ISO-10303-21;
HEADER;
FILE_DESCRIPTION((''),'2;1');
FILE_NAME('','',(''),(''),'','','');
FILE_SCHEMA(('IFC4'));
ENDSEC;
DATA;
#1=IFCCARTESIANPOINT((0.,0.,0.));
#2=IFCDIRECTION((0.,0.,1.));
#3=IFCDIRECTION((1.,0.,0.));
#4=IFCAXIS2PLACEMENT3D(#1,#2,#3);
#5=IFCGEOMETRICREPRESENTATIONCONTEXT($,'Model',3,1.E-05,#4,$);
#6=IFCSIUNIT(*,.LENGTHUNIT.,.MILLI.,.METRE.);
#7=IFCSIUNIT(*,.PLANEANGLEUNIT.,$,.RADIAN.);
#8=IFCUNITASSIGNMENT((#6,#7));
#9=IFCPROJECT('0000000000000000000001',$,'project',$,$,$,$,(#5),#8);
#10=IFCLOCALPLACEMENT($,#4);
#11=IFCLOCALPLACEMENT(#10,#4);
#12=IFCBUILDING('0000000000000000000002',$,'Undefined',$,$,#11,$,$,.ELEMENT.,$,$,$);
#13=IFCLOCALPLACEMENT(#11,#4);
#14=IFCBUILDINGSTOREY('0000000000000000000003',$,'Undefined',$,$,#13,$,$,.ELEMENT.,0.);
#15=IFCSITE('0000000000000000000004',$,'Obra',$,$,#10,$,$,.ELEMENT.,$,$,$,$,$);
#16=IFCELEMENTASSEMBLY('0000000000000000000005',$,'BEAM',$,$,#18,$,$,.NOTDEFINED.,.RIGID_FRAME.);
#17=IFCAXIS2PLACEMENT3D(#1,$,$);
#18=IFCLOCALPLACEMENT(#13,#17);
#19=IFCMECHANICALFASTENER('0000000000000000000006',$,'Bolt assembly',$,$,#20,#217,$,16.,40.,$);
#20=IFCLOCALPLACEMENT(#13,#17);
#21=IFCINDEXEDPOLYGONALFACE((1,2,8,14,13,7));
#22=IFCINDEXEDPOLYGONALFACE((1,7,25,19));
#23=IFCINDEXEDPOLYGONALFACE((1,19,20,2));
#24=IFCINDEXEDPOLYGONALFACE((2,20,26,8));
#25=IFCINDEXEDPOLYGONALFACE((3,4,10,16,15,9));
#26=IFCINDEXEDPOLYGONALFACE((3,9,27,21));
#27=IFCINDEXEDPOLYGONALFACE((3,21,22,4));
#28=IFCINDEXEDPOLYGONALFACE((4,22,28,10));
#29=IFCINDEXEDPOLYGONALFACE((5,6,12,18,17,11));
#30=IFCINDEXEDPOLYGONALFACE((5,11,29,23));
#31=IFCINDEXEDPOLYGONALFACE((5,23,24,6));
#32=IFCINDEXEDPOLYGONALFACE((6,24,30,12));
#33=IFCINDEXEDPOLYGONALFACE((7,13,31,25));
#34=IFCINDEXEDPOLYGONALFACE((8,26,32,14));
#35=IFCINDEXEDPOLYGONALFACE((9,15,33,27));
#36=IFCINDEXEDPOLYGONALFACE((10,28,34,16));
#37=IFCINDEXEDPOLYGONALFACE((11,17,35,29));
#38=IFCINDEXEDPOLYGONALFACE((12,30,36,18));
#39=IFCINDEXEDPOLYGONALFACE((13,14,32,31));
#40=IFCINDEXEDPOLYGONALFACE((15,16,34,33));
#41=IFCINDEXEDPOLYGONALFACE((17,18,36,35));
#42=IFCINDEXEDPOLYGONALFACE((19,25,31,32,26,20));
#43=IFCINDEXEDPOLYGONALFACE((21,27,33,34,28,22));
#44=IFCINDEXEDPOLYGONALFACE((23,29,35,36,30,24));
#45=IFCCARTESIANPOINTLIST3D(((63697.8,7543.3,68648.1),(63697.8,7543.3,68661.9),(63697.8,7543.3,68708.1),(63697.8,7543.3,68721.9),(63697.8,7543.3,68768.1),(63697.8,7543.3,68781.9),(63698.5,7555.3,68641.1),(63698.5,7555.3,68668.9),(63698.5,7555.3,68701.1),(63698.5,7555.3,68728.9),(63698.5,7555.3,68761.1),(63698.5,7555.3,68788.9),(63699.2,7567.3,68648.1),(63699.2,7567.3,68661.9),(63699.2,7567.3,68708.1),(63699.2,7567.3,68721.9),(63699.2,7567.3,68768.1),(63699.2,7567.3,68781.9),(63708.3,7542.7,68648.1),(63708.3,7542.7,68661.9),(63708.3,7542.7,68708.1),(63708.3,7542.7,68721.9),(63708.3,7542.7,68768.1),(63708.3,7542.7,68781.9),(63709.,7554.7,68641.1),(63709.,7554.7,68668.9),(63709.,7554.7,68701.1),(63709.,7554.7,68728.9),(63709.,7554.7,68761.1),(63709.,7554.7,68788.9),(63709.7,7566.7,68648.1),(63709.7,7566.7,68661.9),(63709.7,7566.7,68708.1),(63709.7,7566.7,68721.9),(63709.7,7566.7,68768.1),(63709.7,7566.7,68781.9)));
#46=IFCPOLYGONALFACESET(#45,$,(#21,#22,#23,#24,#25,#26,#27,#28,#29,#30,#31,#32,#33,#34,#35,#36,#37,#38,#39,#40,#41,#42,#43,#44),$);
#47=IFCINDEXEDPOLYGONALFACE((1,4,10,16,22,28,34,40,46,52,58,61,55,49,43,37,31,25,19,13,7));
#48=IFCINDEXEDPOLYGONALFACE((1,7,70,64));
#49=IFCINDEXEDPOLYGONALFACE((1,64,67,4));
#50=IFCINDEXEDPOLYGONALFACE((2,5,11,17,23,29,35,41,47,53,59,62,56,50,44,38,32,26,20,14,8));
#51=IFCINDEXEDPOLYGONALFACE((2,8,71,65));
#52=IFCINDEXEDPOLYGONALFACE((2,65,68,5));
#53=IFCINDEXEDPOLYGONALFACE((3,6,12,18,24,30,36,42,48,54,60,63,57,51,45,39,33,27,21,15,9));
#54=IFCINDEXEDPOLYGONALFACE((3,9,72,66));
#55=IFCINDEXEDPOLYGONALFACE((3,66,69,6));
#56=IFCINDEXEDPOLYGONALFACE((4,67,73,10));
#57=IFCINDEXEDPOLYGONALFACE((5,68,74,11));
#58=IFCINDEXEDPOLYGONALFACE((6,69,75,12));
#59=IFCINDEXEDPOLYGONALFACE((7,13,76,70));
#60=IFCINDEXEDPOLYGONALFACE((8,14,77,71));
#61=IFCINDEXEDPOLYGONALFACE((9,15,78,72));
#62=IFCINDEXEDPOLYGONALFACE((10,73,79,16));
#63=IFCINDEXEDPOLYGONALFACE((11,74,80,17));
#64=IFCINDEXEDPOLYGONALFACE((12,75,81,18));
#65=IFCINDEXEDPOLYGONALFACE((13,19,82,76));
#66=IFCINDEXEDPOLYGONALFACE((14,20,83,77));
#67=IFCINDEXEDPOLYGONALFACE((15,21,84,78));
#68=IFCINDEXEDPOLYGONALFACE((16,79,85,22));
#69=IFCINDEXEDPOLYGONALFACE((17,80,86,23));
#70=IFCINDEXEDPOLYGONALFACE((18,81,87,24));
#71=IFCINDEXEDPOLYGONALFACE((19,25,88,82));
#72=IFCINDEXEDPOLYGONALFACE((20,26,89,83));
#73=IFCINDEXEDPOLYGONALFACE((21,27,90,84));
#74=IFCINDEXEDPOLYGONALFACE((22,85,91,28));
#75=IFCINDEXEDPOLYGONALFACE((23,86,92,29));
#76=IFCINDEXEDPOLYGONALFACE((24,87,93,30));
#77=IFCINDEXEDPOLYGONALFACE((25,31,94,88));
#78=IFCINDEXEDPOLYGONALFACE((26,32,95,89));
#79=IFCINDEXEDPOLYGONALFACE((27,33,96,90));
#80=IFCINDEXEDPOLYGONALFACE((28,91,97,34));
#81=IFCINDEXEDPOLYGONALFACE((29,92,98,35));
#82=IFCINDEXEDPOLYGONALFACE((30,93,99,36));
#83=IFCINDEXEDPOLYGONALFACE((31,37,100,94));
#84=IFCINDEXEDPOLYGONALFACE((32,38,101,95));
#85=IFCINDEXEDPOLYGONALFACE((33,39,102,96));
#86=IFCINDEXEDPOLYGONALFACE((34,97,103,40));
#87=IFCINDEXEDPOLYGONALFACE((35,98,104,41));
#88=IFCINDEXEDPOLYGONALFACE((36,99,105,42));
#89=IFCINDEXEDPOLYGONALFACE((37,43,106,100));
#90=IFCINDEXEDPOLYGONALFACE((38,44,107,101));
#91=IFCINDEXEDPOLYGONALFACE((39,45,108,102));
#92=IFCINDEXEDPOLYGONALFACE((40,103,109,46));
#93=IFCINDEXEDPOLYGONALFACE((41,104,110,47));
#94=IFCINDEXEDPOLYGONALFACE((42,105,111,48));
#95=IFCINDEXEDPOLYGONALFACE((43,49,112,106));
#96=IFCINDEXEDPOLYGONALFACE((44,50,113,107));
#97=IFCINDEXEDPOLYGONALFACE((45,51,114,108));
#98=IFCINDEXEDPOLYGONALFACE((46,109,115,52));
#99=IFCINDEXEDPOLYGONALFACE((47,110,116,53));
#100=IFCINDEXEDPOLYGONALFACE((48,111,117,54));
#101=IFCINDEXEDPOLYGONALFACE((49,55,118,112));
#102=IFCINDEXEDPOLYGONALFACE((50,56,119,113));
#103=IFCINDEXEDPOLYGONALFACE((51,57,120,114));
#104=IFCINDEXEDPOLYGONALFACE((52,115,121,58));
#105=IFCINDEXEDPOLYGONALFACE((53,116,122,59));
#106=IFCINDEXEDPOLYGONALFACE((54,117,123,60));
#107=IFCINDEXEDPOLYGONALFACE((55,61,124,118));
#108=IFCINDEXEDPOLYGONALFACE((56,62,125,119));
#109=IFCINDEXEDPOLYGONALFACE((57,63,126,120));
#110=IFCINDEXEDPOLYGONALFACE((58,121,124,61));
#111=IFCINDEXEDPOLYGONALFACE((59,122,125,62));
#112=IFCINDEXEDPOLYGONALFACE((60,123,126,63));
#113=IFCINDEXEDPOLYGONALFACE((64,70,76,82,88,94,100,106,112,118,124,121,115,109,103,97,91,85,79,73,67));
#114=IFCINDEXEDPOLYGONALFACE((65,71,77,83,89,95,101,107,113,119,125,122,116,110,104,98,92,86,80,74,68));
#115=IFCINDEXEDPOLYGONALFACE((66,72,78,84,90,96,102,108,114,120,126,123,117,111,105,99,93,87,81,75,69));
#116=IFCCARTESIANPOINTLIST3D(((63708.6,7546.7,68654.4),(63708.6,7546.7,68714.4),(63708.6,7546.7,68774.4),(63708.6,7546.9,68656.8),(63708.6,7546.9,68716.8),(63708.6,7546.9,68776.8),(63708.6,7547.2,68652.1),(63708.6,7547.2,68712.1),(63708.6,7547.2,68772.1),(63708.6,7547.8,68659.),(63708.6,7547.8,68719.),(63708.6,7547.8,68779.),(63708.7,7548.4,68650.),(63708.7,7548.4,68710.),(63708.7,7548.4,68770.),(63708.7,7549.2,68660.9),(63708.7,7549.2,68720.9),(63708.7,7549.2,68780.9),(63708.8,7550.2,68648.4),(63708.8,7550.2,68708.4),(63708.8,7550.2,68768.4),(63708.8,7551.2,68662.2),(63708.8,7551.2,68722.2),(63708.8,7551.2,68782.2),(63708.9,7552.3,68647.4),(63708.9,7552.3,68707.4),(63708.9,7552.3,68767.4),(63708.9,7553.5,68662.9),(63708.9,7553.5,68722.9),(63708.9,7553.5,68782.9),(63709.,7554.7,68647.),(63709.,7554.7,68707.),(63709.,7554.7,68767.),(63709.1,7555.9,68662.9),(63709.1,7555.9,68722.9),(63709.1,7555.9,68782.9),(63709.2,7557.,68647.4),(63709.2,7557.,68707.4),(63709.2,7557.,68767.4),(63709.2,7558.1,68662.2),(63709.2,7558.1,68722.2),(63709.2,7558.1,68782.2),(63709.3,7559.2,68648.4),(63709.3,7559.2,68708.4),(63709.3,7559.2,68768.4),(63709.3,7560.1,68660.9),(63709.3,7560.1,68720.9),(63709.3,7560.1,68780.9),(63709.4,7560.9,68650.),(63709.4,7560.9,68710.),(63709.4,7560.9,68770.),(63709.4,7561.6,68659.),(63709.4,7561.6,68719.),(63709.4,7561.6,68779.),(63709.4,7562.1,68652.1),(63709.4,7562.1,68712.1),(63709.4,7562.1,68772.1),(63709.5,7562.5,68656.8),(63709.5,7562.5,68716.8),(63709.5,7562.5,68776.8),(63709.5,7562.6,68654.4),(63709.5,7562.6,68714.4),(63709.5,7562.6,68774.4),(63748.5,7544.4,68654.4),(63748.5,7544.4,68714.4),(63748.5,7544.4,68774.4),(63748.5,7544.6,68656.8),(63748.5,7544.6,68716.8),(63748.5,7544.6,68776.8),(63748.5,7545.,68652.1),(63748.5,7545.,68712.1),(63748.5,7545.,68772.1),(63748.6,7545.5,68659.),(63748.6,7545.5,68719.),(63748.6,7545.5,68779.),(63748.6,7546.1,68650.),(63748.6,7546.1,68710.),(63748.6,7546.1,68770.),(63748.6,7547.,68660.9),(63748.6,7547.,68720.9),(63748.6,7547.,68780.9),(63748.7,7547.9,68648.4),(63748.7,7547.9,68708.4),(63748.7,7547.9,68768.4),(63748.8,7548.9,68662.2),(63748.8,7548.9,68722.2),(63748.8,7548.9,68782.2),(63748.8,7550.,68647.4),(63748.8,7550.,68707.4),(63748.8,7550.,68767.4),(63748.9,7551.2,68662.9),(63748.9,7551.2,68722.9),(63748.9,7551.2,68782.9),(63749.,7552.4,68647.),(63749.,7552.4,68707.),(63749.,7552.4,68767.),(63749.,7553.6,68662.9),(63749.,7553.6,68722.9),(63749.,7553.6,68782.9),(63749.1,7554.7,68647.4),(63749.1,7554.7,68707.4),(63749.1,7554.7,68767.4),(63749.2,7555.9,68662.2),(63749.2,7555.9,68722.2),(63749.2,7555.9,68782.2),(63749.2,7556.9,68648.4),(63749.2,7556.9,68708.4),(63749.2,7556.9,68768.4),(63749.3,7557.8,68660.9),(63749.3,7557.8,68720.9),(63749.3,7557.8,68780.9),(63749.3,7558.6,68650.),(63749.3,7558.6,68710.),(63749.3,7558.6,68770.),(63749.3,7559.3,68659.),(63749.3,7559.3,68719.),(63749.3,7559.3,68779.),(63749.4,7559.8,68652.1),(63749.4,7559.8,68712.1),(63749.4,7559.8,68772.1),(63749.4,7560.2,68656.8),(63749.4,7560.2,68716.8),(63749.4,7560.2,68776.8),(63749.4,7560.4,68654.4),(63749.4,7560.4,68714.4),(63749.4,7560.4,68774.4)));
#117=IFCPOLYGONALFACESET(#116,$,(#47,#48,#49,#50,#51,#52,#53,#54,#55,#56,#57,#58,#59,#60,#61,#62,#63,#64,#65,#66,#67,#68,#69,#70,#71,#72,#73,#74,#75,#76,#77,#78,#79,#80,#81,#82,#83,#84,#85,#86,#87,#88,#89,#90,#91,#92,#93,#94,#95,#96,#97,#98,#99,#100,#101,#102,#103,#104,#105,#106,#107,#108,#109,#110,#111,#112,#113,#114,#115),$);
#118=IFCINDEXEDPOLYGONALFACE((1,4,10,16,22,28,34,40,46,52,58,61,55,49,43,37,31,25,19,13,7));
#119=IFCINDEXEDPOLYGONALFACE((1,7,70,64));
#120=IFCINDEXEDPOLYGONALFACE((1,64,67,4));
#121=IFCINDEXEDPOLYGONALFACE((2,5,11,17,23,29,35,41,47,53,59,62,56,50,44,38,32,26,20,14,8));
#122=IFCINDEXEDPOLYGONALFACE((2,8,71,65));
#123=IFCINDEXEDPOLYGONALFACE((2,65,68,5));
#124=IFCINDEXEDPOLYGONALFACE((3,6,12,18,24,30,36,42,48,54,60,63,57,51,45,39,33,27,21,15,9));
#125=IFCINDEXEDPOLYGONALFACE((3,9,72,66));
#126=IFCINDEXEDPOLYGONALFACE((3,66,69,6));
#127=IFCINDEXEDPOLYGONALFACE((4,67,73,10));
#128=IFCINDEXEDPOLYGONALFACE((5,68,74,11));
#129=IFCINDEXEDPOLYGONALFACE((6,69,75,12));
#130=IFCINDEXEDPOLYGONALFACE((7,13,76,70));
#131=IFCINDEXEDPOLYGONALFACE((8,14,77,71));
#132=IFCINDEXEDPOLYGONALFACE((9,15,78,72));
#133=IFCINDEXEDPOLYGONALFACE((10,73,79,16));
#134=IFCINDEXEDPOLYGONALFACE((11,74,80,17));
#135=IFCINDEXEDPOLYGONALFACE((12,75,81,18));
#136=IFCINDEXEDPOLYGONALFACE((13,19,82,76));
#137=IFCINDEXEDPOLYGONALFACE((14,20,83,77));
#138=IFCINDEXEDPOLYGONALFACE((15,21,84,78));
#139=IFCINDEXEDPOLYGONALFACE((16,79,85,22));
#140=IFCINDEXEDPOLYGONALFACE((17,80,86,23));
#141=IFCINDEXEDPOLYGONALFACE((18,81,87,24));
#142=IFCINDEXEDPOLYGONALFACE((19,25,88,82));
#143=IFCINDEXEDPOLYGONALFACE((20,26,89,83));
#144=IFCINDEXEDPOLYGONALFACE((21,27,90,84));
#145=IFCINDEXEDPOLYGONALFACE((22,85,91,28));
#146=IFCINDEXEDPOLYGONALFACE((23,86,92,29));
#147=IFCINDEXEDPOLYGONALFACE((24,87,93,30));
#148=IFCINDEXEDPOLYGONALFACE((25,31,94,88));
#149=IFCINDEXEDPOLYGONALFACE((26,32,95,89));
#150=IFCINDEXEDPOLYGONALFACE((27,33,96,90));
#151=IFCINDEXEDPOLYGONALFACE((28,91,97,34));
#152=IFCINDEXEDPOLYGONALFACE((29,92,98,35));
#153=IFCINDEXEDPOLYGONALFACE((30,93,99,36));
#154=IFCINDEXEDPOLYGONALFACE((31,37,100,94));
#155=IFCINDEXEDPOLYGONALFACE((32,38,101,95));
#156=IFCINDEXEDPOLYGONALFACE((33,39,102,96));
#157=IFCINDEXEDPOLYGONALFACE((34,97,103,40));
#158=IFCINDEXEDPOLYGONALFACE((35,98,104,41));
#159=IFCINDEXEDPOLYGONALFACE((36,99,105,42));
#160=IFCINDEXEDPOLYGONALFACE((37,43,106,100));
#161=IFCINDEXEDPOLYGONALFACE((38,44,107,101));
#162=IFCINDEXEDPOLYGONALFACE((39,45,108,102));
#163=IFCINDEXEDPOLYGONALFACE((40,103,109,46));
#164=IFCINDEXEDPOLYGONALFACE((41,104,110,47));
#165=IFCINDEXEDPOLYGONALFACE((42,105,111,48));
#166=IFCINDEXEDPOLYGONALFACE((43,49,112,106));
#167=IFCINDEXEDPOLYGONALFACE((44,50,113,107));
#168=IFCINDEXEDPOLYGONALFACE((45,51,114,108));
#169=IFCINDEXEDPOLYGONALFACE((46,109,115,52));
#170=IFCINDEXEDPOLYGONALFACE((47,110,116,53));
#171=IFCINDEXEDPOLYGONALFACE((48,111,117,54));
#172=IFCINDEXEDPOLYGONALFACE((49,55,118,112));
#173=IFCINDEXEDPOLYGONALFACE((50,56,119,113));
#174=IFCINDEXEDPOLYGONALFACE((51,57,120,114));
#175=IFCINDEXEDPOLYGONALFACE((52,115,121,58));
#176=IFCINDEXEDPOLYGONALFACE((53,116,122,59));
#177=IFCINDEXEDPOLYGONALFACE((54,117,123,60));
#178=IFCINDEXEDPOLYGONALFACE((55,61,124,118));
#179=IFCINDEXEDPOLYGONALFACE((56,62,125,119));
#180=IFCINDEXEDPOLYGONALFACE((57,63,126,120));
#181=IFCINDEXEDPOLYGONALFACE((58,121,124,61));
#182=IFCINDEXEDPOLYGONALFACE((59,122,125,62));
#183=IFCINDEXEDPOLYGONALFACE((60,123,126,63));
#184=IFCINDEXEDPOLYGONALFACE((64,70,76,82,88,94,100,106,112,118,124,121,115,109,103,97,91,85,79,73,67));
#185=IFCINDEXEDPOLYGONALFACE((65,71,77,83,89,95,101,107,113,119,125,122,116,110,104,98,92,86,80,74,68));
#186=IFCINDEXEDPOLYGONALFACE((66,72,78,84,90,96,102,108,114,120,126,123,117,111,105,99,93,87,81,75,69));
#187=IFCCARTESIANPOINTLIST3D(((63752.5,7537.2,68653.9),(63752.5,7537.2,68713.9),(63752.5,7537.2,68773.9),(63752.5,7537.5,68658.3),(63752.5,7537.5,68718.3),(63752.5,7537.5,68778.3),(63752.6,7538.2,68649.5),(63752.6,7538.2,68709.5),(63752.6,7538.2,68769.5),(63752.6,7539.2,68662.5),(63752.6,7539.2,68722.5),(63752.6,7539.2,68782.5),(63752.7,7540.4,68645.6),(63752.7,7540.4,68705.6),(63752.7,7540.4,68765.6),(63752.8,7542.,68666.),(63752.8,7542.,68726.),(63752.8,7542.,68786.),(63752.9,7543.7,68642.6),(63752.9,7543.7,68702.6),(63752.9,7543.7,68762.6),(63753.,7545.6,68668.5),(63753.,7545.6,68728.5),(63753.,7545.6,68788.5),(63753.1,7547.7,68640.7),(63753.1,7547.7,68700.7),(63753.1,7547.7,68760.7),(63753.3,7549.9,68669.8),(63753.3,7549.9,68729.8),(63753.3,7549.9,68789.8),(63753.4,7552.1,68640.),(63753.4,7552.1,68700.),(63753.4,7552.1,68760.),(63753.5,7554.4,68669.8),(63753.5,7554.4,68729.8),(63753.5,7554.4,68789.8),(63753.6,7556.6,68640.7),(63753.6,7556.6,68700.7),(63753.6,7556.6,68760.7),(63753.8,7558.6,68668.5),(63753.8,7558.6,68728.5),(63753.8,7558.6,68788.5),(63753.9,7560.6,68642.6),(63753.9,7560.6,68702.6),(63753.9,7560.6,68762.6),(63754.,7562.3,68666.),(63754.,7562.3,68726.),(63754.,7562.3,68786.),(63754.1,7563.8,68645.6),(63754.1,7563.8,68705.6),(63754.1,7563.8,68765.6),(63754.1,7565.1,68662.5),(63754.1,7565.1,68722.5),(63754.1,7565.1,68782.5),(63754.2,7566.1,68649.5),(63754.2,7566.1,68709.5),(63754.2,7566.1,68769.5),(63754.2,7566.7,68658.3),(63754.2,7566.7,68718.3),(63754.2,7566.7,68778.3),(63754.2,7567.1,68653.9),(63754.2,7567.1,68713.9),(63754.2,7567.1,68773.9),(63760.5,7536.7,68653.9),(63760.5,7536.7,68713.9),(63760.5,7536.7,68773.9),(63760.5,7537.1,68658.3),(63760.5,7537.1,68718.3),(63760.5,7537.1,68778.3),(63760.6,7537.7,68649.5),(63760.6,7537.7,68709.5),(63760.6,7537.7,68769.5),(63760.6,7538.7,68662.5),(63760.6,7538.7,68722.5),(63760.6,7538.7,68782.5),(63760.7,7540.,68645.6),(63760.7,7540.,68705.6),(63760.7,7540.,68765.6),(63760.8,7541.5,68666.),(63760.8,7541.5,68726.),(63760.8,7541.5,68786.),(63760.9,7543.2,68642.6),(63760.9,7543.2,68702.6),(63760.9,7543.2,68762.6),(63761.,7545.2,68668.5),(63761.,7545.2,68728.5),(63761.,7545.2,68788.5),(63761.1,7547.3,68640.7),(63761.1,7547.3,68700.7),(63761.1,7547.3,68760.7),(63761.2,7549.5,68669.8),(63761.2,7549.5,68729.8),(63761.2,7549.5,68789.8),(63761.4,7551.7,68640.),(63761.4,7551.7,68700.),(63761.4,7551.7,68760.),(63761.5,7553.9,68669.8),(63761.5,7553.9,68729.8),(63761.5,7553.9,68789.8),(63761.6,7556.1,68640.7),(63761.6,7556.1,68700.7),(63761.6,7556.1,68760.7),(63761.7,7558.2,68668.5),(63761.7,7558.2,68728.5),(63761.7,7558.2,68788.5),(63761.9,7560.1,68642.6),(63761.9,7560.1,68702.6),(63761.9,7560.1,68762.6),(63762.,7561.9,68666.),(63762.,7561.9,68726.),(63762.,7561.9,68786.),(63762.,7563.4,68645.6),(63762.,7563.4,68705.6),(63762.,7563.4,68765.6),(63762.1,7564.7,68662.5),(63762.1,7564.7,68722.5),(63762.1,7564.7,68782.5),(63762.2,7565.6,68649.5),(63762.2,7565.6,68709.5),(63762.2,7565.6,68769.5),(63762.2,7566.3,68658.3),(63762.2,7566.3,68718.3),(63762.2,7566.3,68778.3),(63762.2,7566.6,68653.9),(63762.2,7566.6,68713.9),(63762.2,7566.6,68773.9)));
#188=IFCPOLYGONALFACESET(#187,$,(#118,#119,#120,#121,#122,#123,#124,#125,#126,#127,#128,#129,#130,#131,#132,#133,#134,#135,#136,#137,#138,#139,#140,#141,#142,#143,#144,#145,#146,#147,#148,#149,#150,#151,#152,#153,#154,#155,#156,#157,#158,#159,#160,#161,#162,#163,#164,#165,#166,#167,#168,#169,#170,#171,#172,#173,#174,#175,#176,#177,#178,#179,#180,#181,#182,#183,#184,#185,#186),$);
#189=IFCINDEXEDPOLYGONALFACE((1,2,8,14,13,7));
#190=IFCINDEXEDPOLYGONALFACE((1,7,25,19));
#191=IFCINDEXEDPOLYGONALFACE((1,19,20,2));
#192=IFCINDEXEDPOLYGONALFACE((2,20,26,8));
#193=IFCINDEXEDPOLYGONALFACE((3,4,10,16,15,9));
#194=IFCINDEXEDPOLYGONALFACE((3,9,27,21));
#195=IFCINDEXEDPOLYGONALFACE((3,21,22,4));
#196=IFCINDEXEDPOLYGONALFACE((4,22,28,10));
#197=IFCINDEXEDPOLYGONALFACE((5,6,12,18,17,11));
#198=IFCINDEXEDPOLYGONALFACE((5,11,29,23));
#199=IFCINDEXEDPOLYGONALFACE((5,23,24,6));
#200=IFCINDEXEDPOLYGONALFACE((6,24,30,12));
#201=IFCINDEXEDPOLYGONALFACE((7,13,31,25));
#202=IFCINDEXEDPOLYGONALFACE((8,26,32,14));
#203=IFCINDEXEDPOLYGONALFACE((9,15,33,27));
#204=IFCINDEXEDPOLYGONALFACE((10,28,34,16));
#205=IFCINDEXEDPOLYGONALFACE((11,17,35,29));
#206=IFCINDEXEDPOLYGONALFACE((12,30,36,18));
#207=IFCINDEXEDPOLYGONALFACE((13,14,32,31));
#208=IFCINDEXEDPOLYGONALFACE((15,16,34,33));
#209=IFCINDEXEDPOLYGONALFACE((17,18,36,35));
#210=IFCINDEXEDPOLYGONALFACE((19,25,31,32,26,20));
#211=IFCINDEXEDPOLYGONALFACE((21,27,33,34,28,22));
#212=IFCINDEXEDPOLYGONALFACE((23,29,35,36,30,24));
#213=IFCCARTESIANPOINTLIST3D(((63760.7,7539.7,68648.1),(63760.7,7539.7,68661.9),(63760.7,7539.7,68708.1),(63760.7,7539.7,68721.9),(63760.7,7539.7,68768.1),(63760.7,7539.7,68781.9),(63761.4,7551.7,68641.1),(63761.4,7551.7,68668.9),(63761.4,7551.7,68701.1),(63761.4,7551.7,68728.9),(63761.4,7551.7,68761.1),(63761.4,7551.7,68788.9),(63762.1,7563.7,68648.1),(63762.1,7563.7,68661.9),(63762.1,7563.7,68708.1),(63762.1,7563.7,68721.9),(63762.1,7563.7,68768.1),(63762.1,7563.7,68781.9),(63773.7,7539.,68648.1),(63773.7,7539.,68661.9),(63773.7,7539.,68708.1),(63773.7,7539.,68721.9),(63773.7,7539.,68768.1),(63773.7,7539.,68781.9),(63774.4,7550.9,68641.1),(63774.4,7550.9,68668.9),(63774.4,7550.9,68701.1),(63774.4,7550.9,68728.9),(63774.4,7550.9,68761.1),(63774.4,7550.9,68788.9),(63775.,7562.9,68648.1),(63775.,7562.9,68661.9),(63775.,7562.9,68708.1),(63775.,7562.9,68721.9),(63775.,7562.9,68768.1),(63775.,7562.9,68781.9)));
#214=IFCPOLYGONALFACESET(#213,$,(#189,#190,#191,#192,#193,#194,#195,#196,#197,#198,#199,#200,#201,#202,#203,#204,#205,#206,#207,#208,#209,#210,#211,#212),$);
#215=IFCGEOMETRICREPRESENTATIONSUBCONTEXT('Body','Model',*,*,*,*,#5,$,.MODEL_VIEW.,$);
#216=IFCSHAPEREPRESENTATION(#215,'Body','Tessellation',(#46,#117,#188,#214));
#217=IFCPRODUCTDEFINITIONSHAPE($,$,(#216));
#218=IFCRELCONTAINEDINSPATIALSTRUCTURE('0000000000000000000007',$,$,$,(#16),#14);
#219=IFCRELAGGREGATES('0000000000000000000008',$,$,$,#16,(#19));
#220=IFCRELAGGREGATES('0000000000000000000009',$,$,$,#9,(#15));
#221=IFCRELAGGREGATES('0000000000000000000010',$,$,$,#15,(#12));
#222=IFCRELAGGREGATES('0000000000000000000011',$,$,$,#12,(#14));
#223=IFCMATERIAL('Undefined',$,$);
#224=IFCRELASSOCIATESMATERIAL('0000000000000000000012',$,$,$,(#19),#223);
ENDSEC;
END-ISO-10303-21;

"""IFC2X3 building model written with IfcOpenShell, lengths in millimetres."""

from ifc_helpers import new_model, si_unit, frame, origin_with_axes, origin_2d_with_axis, place, context, subcontext, project, spatial, polyline, circle, outline, extrude, source, transform, mapped, material, element, aggregate, save


model = new_model("IFC2X3")

# Units and contexts
model_context = context("Model", 3, precision=1e-05, world=origin_with_axes())
body_context = subcontext(model_context, "Body", "Model", "MODEL_VIEW")
ifc_project = project(units=[si_unit("LENGTHUNIT", "METRE", prefix="MILLI"), si_unit("PLANEANGLEUNIT", "RADIAN")], contexts=[model_context])

# Site, building, storey
site_placement = place(None, origin_with_axes())
site = spatial("IfcSite", under=ifc_project, at=site_placement, Name="Obra", CompositionType="ELEMENT")
building_placement = place(site_placement, origin_with_axes())
building = spatial("IfcBuilding", under=site, at=building_placement, Name="Undefined", CompositionType="ELEMENT")
storey_placement = place(building_placement, origin_with_axes())
storey = spatial("IfcBuildingStorey", under=building, at=storey_placement, Name="Undefined", CompositionType="ELEMENT", Elevation=0.0)

# Element assembly, mechanical fastener
ifc_material_1 = material(Name="Undefined")
shared_shape_1 = source(origin_with_axes(), body_context, "Body", "SweptSolid", [
    extrude(outline(polyline([(13.9, 0.0), (6.9, 12.0), (-6.9, 12.0), (-13.9, 0.0), (-6.9, -12.0), (6.9, -12.0), (13.9, 0.0)])), frame((0.0, -19.7, 0.0), z_axis=(0.0, 1.0, 0.0), x_axis=(1.0, 0.0, 0.0)), (0.0, 0.0, 1.0), 10.6),
    extrude(circle(Radius=8.0, at=origin_2d_with_axis()), frame((0.0, -9.1, 0.0), z_axis=(0.0, 1.0, 0.0), x_axis=(1.0, 0.0, 0.0)), (0.0, 0.0, 1.0), 40.0),
    extrude(circle(Radius=15.0, at=origin_2d_with_axis()), frame((0.0, 35.3, 0.0), z_axis=(0.0, 1.0, 0.0), x_axis=(1.0, 0.0, 0.0)), (0.0, 0.0, 1.0), 8.0),
    extrude(outline(polyline([(13.9, 0.0), (6.9, 12.0), (-6.9, 12.0), (-13.9, 0.0), (-6.9, -12.0), (6.9, -12.0), (13.9, 0.0)])), frame((0.0, 43.3, 0.0), z_axis=(0.0, 1.0, 0.0), x_axis=(1.0, 0.0, 0.0)), (0.0, 0.0, 1.0), 13.0),
])
assembly_1_placement = place(storey_placement, origin_with_axes())
assembly_1 = element("IfcElementAssembly", 1, at=assembly_1_placement, inside=storey, Name="BEAM", AssemblyPlace="NOTDEFINED", PredefinedType="RIGID_FRAME")
mechanical_fastener_1_placement = place(assembly_1_placement, frame((63721.0, 7604.1, 68835.0), z_axis=(-0.05711, -0.998368, 0.0), x_axis=(0.0, 0.0, -1.0)))
mechanical_fastener_1 = element("IfcMechanicalFastener", 2, at=mechanical_fastener_1_placement, material=ifc_material_1, Name="Bolt assembly", NominalDiameter=16.0, NominalLength=40.0, context=body_context, shape_type="MappedRepresentation", body=[
    mapped(shared_shape_1, transform((60.0, 0.0, 50.0))),
    mapped(shared_shape_1, transform((120.0, 0.0, 50.0))),
    mapped(shared_shape_1, transform((180.0, 0.0, 50.0))),
])
aggregate(assembly_1, [mechanical_fastener_1])

save(model, "model.ifc")
